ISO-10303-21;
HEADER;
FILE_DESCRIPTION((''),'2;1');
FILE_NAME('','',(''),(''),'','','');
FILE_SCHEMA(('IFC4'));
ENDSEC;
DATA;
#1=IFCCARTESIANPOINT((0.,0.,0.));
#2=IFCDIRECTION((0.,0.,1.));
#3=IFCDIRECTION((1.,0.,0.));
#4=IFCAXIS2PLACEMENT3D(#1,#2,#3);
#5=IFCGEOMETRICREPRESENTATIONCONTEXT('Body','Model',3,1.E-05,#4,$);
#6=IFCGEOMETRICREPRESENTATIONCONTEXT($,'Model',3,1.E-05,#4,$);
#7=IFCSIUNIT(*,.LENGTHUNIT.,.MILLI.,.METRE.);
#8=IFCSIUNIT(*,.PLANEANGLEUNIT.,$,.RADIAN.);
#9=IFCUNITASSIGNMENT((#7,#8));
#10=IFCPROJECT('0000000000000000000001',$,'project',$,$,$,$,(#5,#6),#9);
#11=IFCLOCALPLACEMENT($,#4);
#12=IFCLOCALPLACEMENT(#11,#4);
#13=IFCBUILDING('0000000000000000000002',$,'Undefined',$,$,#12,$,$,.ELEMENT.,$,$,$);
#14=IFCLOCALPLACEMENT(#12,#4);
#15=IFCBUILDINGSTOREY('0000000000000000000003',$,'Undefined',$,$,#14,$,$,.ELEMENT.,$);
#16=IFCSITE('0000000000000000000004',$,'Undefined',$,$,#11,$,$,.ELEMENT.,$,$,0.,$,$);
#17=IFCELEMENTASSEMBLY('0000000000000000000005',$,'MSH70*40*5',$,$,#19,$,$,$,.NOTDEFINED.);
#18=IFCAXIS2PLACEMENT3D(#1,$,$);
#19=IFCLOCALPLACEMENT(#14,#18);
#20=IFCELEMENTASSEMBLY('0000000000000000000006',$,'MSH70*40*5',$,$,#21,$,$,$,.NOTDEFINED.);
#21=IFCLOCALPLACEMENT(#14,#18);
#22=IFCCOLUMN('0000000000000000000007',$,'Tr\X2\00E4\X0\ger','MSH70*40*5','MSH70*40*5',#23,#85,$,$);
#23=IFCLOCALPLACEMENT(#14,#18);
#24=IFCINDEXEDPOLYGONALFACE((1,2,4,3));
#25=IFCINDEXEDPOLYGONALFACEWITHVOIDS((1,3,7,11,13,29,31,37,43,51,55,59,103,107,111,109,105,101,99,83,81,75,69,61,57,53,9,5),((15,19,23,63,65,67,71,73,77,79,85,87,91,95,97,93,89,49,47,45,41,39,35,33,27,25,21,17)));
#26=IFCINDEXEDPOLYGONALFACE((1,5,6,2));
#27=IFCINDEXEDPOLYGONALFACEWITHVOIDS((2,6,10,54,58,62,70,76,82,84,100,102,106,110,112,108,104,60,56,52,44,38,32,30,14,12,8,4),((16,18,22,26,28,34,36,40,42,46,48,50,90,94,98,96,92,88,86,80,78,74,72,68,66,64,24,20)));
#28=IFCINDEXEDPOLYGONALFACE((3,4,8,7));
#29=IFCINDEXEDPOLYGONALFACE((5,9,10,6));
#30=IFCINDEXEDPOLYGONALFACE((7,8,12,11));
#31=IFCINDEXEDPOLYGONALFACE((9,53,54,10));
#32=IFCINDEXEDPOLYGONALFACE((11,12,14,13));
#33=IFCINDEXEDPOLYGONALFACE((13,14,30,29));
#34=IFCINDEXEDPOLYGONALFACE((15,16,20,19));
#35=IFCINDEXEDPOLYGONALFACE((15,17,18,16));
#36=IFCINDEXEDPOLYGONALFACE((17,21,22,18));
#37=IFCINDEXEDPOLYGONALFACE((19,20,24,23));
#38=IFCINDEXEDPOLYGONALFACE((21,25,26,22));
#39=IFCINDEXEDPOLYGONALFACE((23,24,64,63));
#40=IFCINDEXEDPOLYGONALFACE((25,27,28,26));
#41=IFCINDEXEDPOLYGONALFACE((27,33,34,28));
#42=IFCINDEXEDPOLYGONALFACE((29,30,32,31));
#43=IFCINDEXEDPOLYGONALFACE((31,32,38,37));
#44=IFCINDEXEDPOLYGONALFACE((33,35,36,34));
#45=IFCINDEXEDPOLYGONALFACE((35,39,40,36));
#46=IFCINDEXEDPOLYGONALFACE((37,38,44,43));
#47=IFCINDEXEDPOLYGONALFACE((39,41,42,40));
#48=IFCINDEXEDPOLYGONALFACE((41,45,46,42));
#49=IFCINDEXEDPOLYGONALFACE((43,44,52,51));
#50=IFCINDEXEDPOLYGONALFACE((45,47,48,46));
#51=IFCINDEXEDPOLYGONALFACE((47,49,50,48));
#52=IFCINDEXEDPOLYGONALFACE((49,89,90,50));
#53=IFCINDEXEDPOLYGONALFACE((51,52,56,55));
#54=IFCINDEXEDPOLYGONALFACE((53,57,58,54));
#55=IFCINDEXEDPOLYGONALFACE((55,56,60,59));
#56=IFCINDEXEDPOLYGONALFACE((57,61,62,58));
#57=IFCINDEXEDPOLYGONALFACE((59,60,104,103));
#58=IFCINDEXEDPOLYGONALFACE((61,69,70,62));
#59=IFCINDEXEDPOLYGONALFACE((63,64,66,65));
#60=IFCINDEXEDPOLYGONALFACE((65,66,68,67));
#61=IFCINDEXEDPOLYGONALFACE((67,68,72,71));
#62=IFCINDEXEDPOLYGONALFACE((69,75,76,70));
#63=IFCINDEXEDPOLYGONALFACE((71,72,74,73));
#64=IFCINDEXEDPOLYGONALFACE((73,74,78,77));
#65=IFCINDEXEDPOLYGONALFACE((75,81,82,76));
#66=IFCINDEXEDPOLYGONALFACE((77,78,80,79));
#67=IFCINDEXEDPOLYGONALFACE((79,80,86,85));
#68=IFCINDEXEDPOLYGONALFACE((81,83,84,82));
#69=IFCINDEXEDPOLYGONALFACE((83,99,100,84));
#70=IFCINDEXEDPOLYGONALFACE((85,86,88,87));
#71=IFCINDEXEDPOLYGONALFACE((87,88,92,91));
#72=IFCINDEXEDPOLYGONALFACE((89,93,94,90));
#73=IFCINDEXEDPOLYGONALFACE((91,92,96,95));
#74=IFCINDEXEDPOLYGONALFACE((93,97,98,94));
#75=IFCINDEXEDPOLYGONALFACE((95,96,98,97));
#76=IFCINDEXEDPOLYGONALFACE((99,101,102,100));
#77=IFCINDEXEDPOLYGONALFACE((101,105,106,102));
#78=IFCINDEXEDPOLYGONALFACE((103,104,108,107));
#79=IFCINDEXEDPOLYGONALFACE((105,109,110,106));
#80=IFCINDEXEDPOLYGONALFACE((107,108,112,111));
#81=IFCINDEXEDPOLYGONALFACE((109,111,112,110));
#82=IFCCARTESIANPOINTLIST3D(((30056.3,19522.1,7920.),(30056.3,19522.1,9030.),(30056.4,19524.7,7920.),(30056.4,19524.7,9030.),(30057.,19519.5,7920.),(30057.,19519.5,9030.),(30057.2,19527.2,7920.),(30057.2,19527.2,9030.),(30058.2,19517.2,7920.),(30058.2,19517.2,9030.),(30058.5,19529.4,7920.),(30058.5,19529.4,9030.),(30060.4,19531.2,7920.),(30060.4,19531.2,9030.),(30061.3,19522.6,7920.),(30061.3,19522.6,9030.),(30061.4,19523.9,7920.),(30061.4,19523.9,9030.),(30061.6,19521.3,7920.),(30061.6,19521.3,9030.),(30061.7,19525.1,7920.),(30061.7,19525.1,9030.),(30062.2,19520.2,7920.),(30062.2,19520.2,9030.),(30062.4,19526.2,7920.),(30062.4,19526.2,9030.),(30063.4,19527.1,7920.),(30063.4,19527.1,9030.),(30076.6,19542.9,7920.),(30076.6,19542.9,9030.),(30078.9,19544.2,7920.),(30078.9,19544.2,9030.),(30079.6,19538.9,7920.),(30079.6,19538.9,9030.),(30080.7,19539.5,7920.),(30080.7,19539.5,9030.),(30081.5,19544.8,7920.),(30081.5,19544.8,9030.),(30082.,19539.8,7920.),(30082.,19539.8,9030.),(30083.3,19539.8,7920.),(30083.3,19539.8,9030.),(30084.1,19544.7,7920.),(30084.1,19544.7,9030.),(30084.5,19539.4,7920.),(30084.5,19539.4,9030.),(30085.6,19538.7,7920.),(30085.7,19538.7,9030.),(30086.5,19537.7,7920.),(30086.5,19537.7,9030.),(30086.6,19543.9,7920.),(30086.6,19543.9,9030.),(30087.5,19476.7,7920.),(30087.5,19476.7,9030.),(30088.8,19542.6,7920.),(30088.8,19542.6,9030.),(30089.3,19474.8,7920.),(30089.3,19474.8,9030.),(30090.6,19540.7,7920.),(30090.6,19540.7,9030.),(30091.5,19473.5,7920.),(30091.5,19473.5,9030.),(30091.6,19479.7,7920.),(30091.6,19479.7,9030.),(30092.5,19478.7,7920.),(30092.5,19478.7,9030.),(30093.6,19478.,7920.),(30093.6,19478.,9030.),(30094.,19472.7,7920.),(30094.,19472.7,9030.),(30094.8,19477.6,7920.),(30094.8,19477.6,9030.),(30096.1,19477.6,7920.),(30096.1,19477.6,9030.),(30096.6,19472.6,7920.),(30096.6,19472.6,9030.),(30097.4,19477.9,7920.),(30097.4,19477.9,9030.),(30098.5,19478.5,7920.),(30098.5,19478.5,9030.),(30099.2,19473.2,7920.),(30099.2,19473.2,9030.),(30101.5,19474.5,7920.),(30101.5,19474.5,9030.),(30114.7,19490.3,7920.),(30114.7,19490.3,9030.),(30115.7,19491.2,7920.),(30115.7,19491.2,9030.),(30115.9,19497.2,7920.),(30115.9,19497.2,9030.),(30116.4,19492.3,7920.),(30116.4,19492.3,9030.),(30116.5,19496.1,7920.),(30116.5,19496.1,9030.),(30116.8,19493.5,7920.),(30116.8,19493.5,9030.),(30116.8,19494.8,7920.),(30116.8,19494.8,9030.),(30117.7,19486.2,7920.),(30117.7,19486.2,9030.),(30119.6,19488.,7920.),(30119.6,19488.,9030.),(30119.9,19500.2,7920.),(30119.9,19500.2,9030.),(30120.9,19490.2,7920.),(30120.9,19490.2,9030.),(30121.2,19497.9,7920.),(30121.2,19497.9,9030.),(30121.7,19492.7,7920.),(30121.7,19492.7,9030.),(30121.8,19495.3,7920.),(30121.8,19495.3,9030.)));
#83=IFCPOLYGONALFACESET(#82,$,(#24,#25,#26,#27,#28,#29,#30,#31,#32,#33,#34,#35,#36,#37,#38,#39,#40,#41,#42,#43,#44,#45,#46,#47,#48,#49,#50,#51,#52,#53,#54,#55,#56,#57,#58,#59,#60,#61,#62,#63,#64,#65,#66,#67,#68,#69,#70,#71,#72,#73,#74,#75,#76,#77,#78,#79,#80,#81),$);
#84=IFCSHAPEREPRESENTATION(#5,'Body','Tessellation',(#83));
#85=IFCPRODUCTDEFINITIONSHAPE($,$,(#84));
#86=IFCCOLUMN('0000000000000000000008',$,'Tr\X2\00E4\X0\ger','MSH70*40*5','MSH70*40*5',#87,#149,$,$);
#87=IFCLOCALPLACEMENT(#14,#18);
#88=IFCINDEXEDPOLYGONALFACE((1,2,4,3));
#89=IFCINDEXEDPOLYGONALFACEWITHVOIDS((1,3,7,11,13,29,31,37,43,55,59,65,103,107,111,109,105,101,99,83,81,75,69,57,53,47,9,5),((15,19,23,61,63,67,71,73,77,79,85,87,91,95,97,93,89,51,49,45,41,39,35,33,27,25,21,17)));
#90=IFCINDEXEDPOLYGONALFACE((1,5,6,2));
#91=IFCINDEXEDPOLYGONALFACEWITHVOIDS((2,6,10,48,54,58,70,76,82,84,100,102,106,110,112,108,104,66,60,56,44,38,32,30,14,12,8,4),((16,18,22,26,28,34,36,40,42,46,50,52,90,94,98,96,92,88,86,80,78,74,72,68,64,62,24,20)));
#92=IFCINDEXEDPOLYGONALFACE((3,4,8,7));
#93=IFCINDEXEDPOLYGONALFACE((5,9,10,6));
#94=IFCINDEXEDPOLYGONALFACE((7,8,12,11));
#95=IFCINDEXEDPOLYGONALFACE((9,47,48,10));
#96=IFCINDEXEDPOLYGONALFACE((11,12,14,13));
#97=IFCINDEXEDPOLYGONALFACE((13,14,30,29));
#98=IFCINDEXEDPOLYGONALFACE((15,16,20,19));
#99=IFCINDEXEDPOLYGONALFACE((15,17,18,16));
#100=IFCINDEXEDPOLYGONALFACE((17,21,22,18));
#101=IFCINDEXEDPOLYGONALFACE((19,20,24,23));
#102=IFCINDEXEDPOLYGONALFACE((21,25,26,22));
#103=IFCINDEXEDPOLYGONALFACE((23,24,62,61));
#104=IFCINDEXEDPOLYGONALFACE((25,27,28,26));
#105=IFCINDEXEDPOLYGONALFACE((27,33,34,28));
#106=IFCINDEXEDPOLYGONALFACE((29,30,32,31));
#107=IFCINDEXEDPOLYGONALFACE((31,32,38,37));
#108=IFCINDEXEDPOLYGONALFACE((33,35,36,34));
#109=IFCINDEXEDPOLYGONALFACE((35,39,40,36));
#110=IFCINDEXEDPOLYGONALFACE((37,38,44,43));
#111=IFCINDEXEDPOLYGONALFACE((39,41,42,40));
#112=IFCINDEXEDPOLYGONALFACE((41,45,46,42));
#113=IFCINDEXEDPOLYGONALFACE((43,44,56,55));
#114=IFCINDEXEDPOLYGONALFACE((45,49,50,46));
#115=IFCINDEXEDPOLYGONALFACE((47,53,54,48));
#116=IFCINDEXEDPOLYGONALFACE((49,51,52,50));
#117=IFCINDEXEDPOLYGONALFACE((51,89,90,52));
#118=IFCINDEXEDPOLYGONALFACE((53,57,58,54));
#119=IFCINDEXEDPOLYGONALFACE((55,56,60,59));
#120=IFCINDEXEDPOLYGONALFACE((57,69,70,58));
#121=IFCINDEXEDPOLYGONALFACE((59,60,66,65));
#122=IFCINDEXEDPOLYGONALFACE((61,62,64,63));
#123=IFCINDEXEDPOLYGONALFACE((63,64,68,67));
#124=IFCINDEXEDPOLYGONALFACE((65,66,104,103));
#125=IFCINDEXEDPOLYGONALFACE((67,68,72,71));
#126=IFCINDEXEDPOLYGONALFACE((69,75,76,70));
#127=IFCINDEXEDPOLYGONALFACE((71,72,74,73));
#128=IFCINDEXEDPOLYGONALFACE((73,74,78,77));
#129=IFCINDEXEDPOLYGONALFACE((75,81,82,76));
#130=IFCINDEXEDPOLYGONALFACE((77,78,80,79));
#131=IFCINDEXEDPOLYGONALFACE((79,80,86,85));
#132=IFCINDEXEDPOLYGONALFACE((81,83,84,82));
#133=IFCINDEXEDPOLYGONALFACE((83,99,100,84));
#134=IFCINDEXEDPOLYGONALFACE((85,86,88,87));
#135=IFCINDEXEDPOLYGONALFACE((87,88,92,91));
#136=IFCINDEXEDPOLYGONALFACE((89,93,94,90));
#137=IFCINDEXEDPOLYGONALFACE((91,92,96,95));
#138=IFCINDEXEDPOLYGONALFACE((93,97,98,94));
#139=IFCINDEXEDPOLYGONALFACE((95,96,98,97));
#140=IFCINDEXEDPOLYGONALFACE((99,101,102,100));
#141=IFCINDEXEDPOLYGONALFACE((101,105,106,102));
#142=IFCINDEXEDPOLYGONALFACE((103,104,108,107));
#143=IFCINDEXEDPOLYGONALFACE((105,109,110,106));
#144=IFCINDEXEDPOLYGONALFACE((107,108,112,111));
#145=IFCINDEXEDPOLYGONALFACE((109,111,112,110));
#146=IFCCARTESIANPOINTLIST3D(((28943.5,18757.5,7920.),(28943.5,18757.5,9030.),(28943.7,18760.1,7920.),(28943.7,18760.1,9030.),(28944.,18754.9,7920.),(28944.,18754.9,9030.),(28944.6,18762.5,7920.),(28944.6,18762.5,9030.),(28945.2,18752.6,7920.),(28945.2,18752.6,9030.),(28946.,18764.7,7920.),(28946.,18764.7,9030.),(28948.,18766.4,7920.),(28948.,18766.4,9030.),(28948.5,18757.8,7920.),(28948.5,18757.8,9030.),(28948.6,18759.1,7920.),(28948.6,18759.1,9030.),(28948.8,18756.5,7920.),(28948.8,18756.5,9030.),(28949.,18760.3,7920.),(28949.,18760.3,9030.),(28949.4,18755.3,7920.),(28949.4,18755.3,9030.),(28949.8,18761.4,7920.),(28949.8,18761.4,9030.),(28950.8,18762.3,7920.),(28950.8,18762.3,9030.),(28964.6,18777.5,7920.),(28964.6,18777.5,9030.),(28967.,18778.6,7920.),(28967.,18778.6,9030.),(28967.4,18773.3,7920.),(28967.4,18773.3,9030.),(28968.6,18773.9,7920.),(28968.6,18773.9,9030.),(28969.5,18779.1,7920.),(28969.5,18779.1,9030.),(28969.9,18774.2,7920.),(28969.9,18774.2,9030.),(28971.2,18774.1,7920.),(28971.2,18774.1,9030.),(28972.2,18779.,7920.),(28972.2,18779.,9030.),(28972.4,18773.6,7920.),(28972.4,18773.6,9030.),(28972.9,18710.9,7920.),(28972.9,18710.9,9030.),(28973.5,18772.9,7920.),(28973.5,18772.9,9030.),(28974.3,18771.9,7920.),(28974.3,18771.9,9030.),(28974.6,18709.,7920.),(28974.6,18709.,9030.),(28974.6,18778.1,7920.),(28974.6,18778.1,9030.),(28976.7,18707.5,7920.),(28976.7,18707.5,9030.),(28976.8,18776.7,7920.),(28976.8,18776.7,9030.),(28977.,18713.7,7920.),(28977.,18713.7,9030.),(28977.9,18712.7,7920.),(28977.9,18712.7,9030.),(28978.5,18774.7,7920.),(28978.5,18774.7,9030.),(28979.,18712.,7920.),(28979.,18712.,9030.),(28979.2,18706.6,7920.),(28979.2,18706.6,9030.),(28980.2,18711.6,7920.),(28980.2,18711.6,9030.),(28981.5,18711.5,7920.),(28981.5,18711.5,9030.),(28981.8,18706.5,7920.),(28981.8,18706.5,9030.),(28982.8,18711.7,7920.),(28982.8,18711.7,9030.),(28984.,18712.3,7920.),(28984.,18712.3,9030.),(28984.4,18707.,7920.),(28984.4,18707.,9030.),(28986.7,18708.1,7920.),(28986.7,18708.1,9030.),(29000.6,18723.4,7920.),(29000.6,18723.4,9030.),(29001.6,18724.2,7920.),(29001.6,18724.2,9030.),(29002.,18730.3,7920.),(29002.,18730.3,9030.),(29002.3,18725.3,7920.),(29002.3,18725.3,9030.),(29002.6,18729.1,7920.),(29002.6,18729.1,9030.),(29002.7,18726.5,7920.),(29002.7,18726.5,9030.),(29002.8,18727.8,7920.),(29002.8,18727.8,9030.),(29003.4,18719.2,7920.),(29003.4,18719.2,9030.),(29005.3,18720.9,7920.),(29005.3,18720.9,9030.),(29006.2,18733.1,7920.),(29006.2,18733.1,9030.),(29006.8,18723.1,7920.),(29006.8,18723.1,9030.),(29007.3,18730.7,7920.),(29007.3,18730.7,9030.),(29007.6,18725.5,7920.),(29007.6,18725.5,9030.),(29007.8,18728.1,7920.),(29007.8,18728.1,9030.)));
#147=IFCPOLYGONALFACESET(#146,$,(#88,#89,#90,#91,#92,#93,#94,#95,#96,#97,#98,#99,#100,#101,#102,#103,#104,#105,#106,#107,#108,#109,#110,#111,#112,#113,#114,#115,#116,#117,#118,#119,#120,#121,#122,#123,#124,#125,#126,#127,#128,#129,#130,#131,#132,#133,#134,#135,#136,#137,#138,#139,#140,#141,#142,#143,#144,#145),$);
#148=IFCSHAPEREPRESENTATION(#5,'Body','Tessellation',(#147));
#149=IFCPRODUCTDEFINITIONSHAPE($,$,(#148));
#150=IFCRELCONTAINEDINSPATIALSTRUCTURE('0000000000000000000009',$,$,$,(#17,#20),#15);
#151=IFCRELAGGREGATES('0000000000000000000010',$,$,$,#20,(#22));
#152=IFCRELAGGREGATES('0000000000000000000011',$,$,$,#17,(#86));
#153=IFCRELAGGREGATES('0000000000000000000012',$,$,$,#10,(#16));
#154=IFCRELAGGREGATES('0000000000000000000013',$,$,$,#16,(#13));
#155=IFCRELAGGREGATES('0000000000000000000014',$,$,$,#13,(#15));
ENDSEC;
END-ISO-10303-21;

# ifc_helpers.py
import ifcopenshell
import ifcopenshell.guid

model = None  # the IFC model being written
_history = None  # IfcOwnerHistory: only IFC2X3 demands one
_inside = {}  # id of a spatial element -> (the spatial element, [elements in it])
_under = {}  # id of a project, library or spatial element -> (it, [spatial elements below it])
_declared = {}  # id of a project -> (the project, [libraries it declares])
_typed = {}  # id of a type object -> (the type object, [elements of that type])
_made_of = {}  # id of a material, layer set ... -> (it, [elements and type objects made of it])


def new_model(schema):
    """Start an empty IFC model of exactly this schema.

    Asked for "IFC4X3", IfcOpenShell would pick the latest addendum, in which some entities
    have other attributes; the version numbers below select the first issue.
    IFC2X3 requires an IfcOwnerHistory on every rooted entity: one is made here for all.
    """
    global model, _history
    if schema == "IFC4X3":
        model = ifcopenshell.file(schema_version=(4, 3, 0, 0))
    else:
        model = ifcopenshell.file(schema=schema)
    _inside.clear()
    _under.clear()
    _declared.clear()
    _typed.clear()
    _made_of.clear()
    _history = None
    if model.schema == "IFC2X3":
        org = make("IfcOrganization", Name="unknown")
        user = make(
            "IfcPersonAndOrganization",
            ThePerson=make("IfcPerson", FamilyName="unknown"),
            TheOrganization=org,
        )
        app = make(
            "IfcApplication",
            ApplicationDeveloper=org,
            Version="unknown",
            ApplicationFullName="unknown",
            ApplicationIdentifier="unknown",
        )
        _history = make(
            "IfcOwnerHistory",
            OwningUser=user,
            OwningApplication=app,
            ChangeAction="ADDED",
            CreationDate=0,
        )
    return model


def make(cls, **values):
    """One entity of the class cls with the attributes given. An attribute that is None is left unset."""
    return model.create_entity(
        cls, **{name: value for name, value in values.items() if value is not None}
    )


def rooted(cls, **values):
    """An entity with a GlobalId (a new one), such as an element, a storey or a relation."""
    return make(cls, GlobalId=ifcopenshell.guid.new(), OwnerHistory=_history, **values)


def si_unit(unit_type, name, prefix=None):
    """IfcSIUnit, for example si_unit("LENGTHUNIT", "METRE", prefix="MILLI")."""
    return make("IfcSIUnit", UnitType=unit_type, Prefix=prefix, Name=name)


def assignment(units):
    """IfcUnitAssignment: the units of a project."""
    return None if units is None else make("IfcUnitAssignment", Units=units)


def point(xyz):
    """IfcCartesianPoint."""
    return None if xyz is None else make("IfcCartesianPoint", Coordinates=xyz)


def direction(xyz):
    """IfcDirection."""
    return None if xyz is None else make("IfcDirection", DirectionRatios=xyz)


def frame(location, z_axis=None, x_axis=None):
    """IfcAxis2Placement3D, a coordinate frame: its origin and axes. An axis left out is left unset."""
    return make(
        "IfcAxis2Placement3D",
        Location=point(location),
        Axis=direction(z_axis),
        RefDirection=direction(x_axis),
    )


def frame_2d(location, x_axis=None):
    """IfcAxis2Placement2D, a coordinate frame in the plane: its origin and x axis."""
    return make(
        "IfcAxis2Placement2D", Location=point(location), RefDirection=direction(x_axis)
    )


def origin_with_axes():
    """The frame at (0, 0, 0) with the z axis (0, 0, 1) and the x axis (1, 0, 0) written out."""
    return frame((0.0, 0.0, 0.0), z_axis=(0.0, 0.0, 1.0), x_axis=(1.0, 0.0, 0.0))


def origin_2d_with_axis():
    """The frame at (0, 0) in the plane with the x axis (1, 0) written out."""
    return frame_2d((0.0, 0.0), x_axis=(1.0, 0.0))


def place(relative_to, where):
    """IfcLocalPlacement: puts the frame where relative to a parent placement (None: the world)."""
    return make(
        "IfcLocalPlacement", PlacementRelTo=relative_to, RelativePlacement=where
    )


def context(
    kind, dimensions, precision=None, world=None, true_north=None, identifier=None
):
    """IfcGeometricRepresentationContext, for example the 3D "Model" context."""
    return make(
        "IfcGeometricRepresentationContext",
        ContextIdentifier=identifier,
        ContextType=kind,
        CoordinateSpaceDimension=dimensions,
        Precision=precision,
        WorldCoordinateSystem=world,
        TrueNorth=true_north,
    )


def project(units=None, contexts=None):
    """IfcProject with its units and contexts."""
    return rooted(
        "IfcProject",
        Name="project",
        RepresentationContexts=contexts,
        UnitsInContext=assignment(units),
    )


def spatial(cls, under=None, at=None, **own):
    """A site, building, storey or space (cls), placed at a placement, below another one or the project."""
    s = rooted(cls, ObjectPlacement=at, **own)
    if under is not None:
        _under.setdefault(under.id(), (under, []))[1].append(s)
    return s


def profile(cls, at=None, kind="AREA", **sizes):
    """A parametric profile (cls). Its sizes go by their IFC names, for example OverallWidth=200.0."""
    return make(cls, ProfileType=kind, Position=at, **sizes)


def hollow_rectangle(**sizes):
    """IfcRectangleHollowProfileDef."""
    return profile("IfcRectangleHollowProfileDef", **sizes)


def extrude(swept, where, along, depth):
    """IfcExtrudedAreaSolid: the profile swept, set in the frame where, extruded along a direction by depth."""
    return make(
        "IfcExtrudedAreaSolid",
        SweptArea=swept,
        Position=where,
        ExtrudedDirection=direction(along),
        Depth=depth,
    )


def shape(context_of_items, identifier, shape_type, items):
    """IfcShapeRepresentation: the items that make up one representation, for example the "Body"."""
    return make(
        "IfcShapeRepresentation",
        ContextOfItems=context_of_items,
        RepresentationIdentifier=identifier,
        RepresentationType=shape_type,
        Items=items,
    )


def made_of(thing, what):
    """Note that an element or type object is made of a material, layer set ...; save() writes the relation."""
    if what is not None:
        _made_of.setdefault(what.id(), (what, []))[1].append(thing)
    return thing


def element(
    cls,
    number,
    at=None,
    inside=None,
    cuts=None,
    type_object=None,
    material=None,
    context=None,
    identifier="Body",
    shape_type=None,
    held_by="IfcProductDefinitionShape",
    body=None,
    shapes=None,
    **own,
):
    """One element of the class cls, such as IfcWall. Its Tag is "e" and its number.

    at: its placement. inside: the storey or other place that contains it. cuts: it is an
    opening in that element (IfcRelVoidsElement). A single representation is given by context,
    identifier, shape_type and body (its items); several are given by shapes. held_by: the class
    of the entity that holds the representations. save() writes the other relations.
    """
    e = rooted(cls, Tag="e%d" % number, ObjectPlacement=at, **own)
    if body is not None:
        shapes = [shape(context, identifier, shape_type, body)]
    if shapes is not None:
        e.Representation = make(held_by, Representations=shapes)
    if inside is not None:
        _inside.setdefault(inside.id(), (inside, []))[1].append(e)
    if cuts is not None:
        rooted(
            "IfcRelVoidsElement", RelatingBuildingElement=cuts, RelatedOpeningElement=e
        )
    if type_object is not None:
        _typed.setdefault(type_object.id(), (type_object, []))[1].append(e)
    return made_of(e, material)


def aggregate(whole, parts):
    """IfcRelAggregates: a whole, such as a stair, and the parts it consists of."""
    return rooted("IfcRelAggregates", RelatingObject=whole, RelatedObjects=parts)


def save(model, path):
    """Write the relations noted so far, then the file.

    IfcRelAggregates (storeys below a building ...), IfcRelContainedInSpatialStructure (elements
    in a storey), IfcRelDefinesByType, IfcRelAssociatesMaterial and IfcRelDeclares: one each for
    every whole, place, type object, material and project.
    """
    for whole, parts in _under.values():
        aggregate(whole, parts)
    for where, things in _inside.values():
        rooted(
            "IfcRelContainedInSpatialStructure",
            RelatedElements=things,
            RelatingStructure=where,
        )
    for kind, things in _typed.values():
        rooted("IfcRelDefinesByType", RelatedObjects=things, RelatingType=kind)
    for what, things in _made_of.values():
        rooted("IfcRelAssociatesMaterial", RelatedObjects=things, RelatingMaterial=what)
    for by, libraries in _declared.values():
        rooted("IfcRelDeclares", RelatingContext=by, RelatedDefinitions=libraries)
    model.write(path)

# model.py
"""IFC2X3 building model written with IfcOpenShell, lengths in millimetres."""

from ifc_helpers import new_model, si_unit, frame, origin_with_axes, origin_2d_with_axis, place, context, project, spatial, hollow_rectangle, extrude, element, aggregate, save


model = new_model("IFC2X3")

# Units and contexts
model_context_1 = context("Model", 3, precision=1e-05, world=origin_with_axes(), identifier="Body")
model_context_2 = context("Model", 3, precision=1e-05, world=origin_with_axes())
ifc_project = project(units=[si_unit("LENGTHUNIT", "METRE", prefix="MILLI"), si_unit("PLANEANGLEUNIT", "RADIAN")], contexts=[model_context_1, model_context_2])

# Site, building, storey
site_placement = place(None, origin_with_axes())
site = spatial("IfcSite", under=ifc_project, at=site_placement, Name="Undefined", CompositionType="ELEMENT", RefElevation=0.0)
building_placement = place(site_placement, origin_with_axes())
building = spatial("IfcBuilding", under=site, at=building_placement, Name="Undefined", CompositionType="ELEMENT")
storey_placement = place(building_placement, origin_with_axes())
storey = spatial("IfcBuildingStorey", under=building, at=storey_placement, Name="Undefined", CompositionType="ELEMENT")

# Element assembly
assembly_1 = element("IfcElementAssembly", 1, inside=storey, Name="MSH70*40*5", PredefinedType="NOTDEFINED")

# Element assembly
assembly_2 = element("IfcElementAssembly", 2, inside=storey, Name="MSH70*40*5", PredefinedType="NOTDEFINED")

# Columns
column_1_placement = place(storey_placement, frame((30089.1, 19508.7, 7920.0), z_axis=(0.0, 0.0, 1.0), x_axis=(1.0, 0.0, 0.0)))
column_1 = element("IfcColumn", 3, at=column_1_placement, Name="Träger", Description="MSH70*40*5", ObjectType="MSH70*40*5", context=model_context_1, shape_type="SweptSolid", body=[
    extrude(hollow_rectangle(XDim=40.0, YDim=70.0, WallThickness=5.0, InnerFilletRadius=5.0, OuterFilletRadius=10.0, at=origin_2d_with_axis()), frame((0.0, 0.0, 1110.0), z_axis=(0.0, 0.0, -1.0), x_axis=(-0.810041, -0.586373, 0.000005)), (0.0, 0.0, 1.0), 1110.0),
])
aggregate(assembly_2, [column_1])
column_2_placement = place(storey_placement, frame((28975.7, 18742.8, 7920.0), z_axis=(0.0, 0.0, 1.0), x_axis=(1.0, 0.0, 0.0)))
column_2 = element("IfcColumn", 4, at=column_2_placement, Name="Träger", Description="MSH70*40*5", ObjectType="MSH70*40*5", context=model_context_1, shape_type="SweptSolid", body=[
    extrude(hollow_rectangle(XDim=40.0, YDim=70.0, WallThickness=5.0, InnerFilletRadius=5.0, OuterFilletRadius=10.0, at=origin_2d_with_axis()), frame((0.0, 0.0, 1110.0), z_axis=(0.0, 0.0, -1.0), x_axis=(-0.832921, -0.553392, 0.000005)), (0.0, 0.0, 1.0), 1110.0),
])
aggregate(assembly_1, [column_2])

save(model, "model.ifc")
